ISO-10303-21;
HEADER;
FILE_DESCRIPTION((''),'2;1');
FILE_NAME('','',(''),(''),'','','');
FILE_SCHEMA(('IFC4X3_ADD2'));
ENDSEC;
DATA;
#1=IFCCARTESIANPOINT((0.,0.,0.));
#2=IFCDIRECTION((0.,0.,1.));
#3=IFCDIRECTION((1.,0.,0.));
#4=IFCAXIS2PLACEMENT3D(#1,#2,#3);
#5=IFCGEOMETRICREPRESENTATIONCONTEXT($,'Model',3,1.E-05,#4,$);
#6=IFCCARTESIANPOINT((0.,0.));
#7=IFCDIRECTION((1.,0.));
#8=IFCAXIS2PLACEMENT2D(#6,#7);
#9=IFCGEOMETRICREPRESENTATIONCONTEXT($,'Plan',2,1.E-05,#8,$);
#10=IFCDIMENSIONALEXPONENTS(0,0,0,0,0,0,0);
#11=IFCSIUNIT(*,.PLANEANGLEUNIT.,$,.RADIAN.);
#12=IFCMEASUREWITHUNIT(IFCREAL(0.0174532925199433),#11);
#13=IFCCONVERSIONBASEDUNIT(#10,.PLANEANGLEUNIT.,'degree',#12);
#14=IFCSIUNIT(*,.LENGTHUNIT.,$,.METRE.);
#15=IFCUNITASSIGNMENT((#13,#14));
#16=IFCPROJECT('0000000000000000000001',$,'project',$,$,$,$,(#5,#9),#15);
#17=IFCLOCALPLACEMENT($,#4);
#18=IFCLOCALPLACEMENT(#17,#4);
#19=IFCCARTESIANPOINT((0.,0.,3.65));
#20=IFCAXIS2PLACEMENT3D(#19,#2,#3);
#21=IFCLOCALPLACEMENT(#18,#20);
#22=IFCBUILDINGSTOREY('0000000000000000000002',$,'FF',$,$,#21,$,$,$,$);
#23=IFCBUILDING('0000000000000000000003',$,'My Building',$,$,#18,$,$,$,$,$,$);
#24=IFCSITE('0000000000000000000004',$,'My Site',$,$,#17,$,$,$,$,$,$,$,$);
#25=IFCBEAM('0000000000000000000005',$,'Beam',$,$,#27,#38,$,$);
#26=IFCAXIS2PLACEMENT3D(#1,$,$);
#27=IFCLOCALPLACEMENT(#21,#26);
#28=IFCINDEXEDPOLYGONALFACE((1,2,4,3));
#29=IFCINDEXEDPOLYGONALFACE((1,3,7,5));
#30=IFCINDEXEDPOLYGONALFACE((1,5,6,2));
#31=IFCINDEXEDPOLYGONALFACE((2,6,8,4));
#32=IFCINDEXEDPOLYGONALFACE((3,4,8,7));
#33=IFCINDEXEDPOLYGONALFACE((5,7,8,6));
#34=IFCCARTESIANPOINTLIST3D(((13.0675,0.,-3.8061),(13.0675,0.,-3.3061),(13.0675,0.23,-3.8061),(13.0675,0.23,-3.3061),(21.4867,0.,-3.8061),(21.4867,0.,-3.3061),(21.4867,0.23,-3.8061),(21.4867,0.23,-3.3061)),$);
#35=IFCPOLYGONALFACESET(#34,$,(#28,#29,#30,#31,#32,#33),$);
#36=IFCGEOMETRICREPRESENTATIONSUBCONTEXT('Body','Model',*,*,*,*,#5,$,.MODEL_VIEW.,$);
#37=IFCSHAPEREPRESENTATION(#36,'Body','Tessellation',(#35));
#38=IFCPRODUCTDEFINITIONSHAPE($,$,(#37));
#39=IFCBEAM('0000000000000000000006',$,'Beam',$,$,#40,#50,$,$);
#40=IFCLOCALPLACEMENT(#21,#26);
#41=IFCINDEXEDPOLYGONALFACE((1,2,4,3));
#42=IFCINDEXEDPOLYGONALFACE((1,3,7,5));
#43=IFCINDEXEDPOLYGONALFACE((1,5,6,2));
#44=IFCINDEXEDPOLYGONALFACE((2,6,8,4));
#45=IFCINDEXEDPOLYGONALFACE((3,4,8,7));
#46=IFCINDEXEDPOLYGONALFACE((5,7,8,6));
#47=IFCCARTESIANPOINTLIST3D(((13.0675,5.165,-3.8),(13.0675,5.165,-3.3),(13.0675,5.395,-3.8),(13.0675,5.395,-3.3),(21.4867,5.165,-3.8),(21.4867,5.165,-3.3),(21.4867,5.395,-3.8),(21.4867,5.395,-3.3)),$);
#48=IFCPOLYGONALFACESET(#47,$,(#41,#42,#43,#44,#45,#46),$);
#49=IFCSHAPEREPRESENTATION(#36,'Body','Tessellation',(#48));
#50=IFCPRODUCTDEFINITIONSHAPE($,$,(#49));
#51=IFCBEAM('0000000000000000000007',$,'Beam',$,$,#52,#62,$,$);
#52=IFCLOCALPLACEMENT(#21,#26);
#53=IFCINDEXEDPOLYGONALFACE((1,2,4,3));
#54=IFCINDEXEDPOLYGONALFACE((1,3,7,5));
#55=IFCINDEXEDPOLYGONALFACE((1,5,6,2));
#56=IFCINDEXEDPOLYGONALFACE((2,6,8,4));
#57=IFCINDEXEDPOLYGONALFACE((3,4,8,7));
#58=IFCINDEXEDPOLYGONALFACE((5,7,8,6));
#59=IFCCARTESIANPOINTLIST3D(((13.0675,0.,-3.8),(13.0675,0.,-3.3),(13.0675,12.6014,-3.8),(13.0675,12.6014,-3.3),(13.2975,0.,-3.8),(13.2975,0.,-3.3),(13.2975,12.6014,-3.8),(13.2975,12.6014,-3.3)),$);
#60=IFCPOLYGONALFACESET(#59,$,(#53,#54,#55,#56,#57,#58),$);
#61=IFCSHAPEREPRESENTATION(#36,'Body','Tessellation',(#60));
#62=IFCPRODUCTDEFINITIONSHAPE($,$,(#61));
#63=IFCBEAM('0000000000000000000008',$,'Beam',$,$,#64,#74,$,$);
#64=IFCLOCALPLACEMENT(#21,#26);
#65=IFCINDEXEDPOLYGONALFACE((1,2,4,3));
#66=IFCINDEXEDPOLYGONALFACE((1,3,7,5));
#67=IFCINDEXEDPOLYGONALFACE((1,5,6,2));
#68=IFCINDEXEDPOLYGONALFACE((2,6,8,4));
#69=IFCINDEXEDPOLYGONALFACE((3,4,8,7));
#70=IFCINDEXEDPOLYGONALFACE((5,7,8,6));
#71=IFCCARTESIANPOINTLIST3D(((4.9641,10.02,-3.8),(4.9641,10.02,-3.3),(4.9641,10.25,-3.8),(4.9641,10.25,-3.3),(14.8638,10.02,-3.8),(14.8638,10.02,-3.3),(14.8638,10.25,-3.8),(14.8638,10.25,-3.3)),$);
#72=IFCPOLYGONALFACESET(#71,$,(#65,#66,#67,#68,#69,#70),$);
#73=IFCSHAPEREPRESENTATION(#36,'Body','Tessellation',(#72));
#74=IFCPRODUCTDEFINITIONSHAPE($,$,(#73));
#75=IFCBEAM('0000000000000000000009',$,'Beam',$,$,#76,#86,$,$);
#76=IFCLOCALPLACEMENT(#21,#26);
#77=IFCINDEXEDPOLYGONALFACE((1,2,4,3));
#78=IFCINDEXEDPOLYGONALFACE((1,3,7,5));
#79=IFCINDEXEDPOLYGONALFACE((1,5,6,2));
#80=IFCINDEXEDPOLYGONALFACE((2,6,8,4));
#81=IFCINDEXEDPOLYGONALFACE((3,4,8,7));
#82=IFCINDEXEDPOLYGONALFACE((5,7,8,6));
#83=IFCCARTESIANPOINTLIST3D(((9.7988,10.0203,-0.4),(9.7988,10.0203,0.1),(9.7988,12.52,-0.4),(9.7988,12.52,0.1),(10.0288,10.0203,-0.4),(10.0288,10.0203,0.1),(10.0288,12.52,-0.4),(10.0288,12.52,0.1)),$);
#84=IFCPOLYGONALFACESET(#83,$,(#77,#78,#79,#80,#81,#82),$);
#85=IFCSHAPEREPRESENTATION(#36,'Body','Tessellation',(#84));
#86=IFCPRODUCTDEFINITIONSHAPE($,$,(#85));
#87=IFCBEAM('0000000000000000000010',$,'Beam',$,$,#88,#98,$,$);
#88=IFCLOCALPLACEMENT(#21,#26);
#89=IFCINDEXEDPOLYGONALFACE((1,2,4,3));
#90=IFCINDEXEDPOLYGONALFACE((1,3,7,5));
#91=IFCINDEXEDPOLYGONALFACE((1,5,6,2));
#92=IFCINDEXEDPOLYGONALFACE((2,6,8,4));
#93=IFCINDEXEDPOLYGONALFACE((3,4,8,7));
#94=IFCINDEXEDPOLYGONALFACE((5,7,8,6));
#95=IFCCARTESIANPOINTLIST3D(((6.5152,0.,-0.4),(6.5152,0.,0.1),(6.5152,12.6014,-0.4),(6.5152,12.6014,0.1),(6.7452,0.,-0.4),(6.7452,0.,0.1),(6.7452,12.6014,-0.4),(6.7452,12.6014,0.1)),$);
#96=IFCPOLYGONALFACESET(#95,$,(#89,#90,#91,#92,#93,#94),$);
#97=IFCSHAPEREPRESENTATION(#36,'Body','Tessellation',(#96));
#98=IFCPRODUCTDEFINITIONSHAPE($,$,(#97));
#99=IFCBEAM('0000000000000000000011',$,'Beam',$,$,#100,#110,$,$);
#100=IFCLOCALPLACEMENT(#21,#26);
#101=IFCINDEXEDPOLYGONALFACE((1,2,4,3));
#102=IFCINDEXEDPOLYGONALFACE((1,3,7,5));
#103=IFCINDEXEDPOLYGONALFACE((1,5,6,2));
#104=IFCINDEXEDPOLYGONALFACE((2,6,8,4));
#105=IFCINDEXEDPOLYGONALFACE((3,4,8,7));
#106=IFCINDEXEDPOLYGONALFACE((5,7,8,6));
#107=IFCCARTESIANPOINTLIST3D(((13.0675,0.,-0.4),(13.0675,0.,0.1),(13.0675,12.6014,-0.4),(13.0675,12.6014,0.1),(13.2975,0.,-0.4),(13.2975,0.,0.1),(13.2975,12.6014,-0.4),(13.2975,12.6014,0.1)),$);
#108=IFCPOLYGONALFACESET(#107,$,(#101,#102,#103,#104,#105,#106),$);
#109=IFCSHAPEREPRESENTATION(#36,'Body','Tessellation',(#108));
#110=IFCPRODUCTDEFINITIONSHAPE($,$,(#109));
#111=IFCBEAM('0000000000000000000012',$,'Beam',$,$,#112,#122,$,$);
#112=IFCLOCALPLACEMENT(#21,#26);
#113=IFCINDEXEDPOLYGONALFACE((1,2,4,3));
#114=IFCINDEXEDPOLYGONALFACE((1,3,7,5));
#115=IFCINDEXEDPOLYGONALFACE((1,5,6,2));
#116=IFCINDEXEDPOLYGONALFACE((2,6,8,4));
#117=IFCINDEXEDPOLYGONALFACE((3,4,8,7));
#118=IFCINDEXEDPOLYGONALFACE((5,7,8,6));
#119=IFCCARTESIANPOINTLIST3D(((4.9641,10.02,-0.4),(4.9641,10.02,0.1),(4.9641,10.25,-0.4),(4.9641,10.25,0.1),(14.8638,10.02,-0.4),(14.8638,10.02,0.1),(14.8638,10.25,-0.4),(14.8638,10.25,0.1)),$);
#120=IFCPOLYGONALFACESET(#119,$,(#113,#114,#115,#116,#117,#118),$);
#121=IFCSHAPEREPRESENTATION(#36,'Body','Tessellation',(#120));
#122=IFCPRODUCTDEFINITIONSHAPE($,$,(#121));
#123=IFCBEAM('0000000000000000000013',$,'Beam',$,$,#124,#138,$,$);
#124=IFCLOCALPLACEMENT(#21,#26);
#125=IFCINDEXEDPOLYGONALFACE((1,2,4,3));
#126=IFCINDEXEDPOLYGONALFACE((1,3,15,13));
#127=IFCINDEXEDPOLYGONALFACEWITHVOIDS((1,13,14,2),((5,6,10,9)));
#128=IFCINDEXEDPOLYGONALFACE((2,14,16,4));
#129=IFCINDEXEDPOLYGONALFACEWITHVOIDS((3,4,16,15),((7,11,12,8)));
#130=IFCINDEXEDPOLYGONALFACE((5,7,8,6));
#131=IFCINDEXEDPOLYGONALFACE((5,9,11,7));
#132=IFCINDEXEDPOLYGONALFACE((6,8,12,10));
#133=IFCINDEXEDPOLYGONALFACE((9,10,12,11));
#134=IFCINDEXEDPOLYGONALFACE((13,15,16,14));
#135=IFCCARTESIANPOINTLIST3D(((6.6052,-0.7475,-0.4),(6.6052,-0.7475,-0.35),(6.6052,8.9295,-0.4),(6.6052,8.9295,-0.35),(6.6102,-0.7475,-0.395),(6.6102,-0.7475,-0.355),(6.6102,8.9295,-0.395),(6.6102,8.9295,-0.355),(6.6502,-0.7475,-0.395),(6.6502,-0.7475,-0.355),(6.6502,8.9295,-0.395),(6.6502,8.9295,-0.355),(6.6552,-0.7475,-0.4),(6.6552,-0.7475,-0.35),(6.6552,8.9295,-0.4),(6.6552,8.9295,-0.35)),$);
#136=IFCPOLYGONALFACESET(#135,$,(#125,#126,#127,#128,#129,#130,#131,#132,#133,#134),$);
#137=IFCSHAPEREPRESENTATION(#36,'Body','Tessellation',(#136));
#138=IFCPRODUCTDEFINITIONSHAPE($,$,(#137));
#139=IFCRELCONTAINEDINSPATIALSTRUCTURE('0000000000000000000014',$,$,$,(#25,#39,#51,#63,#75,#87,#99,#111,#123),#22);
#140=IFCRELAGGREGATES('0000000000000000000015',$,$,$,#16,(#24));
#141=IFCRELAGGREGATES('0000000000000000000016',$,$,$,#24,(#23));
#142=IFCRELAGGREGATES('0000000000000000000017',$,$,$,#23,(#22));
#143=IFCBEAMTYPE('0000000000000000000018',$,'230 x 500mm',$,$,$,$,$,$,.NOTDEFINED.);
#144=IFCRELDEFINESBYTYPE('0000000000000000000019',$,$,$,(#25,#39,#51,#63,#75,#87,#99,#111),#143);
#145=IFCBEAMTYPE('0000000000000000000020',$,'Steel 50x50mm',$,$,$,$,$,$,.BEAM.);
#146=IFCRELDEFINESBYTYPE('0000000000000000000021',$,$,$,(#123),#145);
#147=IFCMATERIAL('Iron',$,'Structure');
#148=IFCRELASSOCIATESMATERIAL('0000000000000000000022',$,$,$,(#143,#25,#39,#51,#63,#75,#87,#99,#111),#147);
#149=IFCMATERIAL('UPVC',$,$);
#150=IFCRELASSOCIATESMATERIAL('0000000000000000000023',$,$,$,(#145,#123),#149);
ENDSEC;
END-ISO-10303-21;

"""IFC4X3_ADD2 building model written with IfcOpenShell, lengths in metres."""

from ifc_helpers import new_model, entity, si_unit, converted_unit, frame, origin_with_axes, origin_2d_with_axis, place, context, subcontext, project, spatial, rectangle, hollow_rectangle, extrude, material, material_profile, profile_set, profile_usage, type_object, element, save


model = new_model("IFC4X3_ADD2")

# Units and contexts
model_context = context("Model", 3, precision=1e-05, world=origin_with_axes())
plan_context = context("Plan", 2, precision=1e-05, world=origin_2d_with_axis())
body_context = subcontext(model_context, "Body", "Model", "MODEL_VIEW")
ifc_project = project(units=[converted_unit("PLANEANGLEUNIT", "degree", entity("IfcReal", 0.0174532925199433), si_unit("PLANEANGLEUNIT", "RADIAN"), dimensions=[0, 0, 0, 0, 0, 0, 0]), si_unit("LENGTHUNIT", "METRE")], contexts=[model_context, plan_context])

# Site, building, storey
site_placement = place(None, origin_with_axes())
site = spatial("IfcSite", under=ifc_project, at=site_placement, Name="My Site")
building_placement = place(site_placement, origin_with_axes())
building = spatial("IfcBuilding", under=site, at=building_placement, Name="My Building")
storey_placement = place(building_placement, frame((0.0, 0.0, 3.65), z_axis=(0.0, 0.0, 1.0), x_axis=(1.0, 0.0, 0.0)))
storey = spatial("IfcBuildingStorey", under=building, at=storey_placement, Name="FF")

# Beams
ifc_material_1 = material(Name="Iron", Category="Structure")
ifc_material_profile_1 = material_profile(ifc_material_1, rectangle(XDim=0.23, YDim=0.5))
ifc_profile_set_1 = profile_set([ifc_material_profile_1])
beam_type_1 = type_object("IfcBeamType", Name="230 x 500mm", PredefinedType="NOTDEFINED", material=ifc_profile_set_1)
ifc_profile_usage_1 = profile_usage(ifc_profile_set_1)
beam_1_placement = place(storey_placement, frame((13.0675, 0.115, -3.5561), z_axis=(1.0, 0.0, 0.0), x_axis=(0.0, 1.0, 0.0)))
element("IfcBeam", 1, at=beam_1_placement, inside=storey, type_object=beam_type_1, material=ifc_profile_usage_1, Name="Beam", context=body_context, shape_type="SweptSolid", body=[
    extrude(rectangle(XDim=0.23, YDim=0.5), origin_with_axes(), (0.0, 0.0, 1.0), 8.4193),
])
ifc_profile_usage_2 = profile_usage(ifc_profile_set_1)
beam_2_placement = place(storey_placement, frame((13.0675, 5.28, -3.55), z_axis=(1.0, 0.0, 0.0), x_axis=(0.0, 1.0, 0.0)))
element("IfcBeam", 2, at=beam_2_placement, inside=storey, type_object=beam_type_1, material=ifc_profile_usage_2, Name="Beam", context=body_context, shape_type="SweptSolid", body=[
    extrude(rectangle(XDim=0.23, YDim=0.5), origin_with_axes(), (0.0, 0.0, 1.0), 8.4193),
])
ifc_profile_usage_3 = profile_usage(ifc_profile_set_1)
beam_3_placement = place(storey_placement, frame((13.1825, 0.0, -3.55), z_axis=(0.0, 1.0, 0.0), x_axis=(-1.0, 0.0, 0.0)))
element("IfcBeam", 3, at=beam_3_placement, inside=storey, type_object=beam_type_1, material=ifc_profile_usage_3, Name="Beam", context=body_context, shape_type="SweptSolid", body=[
    extrude(rectangle(XDim=0.23, YDim=0.5), origin_with_axes(), (0.0, 0.0, 1.0), 12.6014),
])
ifc_profile_usage_4 = profile_usage(ifc_profile_set_1)
beam_4_placement = place(storey_placement, frame((4.9641, 10.135, -3.55), z_axis=(1.0, 0.0, 0.0), x_axis=(0.0, 1.0, 0.0)))
element("IfcBeam", 4, at=beam_4_placement, inside=storey, type_object=beam_type_1, material=ifc_profile_usage_4, Name="Beam", context=body_context, shape_type="SweptSolid", body=[
    extrude(rectangle(XDim=0.23, YDim=0.5), origin_with_axes(), (0.0, 0.0, 1.0), 9.8997),
])
ifc_profile_usage_5 = profile_usage(ifc_profile_set_1)
beam_5_placement = place(storey_placement, frame((9.9138, 12.52, -0.15), z_axis=(0.0, -1.0, 0.0), x_axis=(1.0, 0.0, 0.0)))
element("IfcBeam", 5, at=beam_5_placement, inside=storey, type_object=beam_type_1, material=ifc_profile_usage_5, Name="Beam", context=body_context, shape_type="SweptSolid", body=[
    extrude(rectangle(XDim=0.23, YDim=0.5), origin_with_axes(), (0.0, 0.0, 1.0), 2.4997),
])
ifc_profile_usage_6 = profile_usage(ifc_profile_set_1)
beam_6_placement = place(storey_placement, frame((6.6302, 0.0, -0.15), z_axis=(0.0, 1.0, 0.0), x_axis=(-1.0, 0.0, 0.0)))
element("IfcBeam", 6, at=beam_6_placement, inside=storey, type_object=beam_type_1, material=ifc_profile_usage_6, Name="Beam", context=body_context, shape_type="SweptSolid", body=[
    extrude(rectangle(XDim=0.23, YDim=0.5), origin_with_axes(), (0.0, 0.0, 1.0), 12.6014),
])
ifc_profile_usage_7 = profile_usage(ifc_profile_set_1)
beam_7_placement = place(storey_placement, frame((13.1825, 0.0, -0.15), z_axis=(0.0, 1.0, 0.0), x_axis=(-1.0, 0.0, 0.0)))
element("IfcBeam", 7, at=beam_7_placement, inside=storey, type_object=beam_type_1, material=ifc_profile_usage_7, Name="Beam", context=body_context, shape_type="SweptSolid", body=[
    extrude(rectangle(XDim=0.23, YDim=0.5), origin_with_axes(), (0.0, 0.0, 1.0), 12.6014),
])
ifc_profile_usage_8 = profile_usage(ifc_profile_set_1)
beam_8_placement = place(storey_placement, frame((4.9641, 10.135, -0.15), z_axis=(1.0, 0.0, 0.0), x_axis=(0.0, 1.0, 0.0)))
element("IfcBeam", 8, at=beam_8_placement, inside=storey, type_object=beam_type_1, material=ifc_profile_usage_8, Name="Beam", context=body_context, shape_type="SweptSolid", body=[
    extrude(rectangle(XDim=0.23, YDim=0.5), origin_with_axes(), (0.0, 0.0, 1.0), 9.8997),
])
ifc_material_2 = material(Name="UPVC")
ifc_material_profile_2 = material_profile(ifc_material_2, hollow_rectangle(XDim=0.05, YDim=0.05, WallThickness=0.005))
ifc_material_profile_3 = material_profile(ifc_material_2, hollow_rectangle(XDim=0.05, YDim=0.05, WallThickness=0.005))
ifc_profile_set_2 = profile_set([ifc_material_profile_2, ifc_material_profile_3])
ifc_profile_usage_9 = profile_usage(ifc_profile_set_2)
beam_type_2 = type_object("IfcBeamType", Name="Steel 50x50mm", PredefinedType="BEAM", material=ifc_profile_set_2)
beam_9_placement = place(storey_placement, frame((6.6302, -0.7475, -0.375), z_axis=(0.0, 1.0, 0.0), x_axis=(-1.0, 0.0, 0.0)))
element("IfcBeam", 9, at=beam_9_placement, inside=storey, type_object=beam_type_2, material=ifc_profile_usage_9, Name="Beam", context=body_context, shape_type="SweptSolid", body=[
    extrude(hollow_rectangle(XDim=0.05, YDim=0.05, WallThickness=0.005), origin_with_axes(), (0.0, 0.0, 1.0), 9.677),
])

save(model, "model.ifc")
